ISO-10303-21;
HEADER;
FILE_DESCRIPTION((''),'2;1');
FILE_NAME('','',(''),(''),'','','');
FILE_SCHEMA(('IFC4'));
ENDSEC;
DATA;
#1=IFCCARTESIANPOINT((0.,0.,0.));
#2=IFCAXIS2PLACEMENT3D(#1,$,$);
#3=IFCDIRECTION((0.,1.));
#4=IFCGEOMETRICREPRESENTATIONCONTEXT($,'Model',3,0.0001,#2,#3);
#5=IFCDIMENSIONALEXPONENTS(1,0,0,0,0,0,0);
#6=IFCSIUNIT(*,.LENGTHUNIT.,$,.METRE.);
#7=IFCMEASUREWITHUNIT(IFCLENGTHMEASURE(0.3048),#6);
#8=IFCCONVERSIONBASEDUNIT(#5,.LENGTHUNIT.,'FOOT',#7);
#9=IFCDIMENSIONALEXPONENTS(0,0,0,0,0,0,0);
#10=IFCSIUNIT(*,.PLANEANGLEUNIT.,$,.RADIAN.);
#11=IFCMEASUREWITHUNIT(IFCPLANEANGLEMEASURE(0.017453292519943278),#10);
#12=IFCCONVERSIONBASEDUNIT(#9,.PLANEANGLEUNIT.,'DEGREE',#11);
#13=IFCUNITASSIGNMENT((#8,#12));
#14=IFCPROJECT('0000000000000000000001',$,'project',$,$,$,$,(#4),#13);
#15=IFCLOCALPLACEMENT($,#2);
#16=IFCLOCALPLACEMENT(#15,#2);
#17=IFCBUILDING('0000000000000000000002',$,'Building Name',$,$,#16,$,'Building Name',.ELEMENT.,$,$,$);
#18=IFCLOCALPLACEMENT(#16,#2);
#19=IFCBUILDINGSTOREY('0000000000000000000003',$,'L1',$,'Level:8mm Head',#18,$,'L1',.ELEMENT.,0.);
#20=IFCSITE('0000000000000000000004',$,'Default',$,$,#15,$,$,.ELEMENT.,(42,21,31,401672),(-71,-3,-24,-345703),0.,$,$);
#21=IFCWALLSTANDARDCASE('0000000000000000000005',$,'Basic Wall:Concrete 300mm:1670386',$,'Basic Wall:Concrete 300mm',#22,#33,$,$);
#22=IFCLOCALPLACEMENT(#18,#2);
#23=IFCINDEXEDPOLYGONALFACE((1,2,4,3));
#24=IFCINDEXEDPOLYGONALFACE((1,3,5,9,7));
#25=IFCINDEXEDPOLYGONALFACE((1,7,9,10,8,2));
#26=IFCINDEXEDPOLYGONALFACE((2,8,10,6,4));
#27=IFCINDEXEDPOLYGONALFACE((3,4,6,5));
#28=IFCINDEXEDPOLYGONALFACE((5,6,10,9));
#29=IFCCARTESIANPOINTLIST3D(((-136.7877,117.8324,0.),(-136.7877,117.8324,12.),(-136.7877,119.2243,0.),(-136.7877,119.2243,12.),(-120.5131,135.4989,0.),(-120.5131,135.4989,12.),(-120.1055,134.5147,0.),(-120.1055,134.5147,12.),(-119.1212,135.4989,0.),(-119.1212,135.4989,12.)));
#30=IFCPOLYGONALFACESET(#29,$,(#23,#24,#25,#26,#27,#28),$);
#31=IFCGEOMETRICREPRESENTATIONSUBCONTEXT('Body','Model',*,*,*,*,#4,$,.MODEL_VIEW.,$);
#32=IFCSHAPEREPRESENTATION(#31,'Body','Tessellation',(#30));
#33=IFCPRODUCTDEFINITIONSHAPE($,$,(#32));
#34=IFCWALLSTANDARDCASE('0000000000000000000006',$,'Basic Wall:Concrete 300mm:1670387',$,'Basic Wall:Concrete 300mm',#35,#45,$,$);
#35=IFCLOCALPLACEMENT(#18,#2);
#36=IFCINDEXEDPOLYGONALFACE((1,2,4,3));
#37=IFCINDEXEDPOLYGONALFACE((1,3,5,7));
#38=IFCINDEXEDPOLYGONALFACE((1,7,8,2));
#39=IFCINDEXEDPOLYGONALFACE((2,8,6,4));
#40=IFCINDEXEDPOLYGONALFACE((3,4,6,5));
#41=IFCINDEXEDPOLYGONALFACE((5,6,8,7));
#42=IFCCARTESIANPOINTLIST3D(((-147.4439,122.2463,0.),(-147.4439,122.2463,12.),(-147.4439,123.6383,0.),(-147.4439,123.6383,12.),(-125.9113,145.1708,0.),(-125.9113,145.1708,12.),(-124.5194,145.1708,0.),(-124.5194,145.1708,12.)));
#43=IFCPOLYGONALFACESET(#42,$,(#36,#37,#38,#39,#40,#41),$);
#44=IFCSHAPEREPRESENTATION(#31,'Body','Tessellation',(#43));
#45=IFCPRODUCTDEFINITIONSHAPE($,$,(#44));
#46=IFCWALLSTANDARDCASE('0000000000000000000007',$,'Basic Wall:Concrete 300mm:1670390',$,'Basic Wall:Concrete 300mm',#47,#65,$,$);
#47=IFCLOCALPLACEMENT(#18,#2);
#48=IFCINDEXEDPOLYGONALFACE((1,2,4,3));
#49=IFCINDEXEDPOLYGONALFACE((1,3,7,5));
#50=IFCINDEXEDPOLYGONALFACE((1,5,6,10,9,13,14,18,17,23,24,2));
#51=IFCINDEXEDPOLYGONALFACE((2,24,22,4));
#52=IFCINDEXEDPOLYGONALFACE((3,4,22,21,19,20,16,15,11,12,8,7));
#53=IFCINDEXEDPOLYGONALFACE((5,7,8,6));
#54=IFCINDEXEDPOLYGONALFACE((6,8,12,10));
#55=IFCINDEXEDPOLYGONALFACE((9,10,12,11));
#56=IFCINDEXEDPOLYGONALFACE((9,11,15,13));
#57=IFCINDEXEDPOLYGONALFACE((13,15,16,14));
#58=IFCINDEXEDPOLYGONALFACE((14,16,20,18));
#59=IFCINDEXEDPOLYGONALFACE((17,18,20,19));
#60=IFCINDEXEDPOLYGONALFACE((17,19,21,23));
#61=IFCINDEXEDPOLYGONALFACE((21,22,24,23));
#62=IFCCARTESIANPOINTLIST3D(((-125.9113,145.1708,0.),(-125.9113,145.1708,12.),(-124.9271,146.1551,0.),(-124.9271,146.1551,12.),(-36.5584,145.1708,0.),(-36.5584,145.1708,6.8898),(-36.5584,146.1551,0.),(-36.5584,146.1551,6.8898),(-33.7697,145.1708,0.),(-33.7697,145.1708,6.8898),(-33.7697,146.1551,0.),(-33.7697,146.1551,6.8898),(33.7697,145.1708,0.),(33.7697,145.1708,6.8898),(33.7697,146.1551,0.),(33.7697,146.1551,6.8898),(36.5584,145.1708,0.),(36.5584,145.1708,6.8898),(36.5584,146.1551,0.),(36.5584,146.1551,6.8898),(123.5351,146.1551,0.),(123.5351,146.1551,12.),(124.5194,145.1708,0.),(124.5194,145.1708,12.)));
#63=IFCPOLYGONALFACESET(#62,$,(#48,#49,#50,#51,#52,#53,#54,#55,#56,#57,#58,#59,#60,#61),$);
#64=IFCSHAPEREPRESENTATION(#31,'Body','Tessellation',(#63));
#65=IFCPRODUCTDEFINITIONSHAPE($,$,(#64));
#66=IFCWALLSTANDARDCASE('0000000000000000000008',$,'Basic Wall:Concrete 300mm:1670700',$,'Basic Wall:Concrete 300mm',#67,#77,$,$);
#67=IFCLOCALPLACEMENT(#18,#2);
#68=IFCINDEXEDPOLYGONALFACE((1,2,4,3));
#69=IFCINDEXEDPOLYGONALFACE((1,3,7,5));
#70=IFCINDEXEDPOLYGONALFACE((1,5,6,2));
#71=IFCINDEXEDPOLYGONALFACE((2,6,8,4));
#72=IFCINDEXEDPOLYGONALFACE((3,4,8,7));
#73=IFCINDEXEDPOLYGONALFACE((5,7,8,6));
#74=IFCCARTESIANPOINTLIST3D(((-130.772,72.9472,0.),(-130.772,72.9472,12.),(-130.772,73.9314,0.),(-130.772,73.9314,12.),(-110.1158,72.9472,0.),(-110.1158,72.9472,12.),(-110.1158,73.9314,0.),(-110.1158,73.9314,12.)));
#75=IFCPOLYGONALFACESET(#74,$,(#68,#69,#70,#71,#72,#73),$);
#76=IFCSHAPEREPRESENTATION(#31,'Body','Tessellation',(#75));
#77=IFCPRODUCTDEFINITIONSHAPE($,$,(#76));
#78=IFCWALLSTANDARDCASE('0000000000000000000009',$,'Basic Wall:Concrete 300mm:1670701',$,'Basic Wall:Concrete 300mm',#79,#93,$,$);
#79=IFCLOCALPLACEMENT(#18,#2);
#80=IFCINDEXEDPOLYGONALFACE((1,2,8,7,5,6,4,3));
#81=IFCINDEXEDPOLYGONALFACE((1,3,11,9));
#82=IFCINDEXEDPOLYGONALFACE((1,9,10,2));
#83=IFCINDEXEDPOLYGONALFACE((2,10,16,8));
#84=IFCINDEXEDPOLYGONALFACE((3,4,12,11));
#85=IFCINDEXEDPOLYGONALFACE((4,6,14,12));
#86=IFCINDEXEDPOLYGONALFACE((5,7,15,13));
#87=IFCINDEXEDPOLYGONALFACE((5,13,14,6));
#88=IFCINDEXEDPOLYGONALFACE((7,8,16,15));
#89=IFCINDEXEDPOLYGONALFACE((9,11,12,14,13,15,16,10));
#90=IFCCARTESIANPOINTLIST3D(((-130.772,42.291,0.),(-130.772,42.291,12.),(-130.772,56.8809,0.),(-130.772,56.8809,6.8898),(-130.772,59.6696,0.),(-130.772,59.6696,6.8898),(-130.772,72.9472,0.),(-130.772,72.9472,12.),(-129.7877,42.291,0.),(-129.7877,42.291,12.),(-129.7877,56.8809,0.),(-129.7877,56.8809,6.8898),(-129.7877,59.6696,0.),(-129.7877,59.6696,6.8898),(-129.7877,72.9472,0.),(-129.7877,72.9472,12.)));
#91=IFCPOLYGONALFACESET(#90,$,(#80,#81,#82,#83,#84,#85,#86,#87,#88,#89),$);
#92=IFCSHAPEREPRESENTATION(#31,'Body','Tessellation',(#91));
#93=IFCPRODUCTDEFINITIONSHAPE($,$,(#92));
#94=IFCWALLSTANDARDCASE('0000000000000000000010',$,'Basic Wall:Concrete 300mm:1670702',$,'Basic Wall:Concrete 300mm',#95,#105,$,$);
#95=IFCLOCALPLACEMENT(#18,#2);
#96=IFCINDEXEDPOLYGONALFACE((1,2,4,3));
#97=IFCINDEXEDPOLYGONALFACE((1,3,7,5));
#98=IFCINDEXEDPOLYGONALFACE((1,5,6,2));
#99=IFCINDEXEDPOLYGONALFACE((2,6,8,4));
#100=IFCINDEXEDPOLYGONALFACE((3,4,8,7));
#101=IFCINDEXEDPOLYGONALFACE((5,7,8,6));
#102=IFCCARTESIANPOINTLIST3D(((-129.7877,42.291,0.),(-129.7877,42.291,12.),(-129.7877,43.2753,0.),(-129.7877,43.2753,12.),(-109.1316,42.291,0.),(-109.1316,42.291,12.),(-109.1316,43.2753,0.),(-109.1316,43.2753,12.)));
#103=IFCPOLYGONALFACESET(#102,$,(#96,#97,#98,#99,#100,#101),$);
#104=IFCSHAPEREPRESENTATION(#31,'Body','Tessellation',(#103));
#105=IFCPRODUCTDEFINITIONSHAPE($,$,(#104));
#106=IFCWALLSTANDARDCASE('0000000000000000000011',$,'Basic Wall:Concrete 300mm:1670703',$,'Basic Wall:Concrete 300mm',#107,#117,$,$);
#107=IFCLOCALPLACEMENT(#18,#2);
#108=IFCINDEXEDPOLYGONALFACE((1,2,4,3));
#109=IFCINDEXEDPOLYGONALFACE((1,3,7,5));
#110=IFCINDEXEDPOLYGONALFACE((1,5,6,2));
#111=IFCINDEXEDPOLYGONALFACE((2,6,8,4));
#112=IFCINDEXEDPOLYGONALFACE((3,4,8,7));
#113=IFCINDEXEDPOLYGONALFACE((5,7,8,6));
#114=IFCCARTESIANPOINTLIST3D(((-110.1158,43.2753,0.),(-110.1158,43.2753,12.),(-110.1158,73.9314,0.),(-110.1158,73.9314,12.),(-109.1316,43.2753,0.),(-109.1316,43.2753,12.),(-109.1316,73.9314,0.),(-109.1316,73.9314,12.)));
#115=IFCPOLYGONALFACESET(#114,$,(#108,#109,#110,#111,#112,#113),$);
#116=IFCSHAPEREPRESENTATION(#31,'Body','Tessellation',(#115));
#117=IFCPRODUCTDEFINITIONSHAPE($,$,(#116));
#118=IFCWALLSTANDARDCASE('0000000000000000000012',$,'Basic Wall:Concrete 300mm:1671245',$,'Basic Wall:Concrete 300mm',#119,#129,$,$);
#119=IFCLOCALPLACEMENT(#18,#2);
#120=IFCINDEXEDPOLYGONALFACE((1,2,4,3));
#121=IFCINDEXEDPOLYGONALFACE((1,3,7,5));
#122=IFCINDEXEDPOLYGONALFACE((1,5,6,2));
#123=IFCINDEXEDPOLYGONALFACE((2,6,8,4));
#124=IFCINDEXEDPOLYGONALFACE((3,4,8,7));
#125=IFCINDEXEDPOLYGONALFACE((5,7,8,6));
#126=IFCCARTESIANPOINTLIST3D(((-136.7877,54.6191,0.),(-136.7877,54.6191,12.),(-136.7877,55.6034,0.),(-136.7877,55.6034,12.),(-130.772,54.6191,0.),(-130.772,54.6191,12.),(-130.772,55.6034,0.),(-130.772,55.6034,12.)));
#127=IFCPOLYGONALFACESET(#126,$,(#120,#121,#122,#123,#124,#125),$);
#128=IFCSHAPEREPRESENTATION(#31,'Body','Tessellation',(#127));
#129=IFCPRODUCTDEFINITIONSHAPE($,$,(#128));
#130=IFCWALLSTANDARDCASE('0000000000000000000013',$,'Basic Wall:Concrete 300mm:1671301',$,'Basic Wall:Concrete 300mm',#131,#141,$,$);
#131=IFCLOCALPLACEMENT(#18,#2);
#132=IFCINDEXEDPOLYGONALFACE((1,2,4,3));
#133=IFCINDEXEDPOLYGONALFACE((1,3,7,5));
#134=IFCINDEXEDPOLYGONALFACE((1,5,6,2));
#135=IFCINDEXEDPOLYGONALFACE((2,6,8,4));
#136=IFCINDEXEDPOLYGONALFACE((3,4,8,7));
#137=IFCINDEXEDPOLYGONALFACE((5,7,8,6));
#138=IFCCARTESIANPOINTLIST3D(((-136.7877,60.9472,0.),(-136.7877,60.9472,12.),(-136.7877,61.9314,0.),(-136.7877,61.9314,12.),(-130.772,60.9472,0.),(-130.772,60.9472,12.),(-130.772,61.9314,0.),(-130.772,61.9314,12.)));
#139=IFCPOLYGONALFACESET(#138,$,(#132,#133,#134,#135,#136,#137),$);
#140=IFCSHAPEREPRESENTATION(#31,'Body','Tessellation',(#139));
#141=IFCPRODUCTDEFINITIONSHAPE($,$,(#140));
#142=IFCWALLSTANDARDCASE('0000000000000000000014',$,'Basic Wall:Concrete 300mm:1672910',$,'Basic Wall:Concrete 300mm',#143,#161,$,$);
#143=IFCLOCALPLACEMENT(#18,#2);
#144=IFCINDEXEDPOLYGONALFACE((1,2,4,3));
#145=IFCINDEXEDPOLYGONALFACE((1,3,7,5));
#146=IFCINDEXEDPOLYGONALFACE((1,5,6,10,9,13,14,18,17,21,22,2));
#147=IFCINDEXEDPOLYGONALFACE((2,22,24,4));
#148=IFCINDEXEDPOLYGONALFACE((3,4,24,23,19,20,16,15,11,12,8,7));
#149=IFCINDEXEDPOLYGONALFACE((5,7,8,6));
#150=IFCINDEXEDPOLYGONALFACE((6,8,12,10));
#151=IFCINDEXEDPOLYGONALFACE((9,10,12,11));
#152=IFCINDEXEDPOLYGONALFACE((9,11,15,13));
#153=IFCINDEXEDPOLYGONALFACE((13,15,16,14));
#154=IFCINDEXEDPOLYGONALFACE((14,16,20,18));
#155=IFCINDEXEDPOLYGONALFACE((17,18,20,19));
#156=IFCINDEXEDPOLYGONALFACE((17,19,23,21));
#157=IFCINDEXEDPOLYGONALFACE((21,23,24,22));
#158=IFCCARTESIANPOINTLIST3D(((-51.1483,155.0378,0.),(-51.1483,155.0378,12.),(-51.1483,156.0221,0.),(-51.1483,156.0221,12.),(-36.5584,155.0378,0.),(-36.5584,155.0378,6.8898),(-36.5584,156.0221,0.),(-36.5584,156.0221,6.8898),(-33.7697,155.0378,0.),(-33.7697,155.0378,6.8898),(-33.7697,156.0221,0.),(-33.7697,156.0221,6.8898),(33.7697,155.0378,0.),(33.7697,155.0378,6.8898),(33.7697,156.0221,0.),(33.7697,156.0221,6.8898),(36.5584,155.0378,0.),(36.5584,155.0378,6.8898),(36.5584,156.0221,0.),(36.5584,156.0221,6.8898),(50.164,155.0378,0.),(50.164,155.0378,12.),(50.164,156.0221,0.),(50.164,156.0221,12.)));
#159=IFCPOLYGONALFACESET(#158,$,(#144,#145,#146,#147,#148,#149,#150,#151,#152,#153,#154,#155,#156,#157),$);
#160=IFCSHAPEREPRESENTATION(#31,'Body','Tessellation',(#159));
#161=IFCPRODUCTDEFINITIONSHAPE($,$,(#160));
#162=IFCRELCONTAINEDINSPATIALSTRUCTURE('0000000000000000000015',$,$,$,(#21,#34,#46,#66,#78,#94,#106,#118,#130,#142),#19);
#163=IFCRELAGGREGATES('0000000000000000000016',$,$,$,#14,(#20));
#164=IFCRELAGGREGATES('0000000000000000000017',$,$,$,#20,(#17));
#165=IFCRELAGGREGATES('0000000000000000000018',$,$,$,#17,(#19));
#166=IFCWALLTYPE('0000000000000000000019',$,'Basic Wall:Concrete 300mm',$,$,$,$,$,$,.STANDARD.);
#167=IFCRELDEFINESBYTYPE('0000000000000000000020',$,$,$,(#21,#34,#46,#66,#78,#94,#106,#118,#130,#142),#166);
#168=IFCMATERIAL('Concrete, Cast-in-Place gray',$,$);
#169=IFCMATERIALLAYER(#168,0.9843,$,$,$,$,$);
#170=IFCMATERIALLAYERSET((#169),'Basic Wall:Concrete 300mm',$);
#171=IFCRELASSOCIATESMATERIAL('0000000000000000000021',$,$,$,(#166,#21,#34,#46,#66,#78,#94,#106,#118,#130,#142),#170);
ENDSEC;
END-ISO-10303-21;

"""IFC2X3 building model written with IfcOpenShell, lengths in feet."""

from ifc_helpers import new_model, entity, si_unit, converted_unit, direction, frame, frame_2d, origin, place, context, subcontext, project, spatial, polyline, rectangle, outline, extrude, material, layer, layer_set, layer_usage, type_object, element, save


model = new_model("IFC2X3")

# Units and contexts
model_context = context("Model", 3, precision=0.0001, world=origin(), true_north=direction((0.0, 1.0)))
body_context = subcontext(model_context, "Body", "Model", "MODEL_VIEW")
ifc_project = project(units=[converted_unit("LENGTHUNIT", "FOOT", entity("IfcLengthMeasure", 0.3048), si_unit("LENGTHUNIT", "METRE"), dimensions=[1, 0, 0, 0, 0, 0, 0]), converted_unit("PLANEANGLEUNIT", "DEGREE", entity("IfcPlaneAngleMeasure", 0.017453292519943278), si_unit("PLANEANGLEUNIT", "RADIAN"), dimensions=[0, 0, 0, 0, 0, 0, 0])], contexts=[model_context])

# Site, building, storey
site_placement = place(None, origin())
site = spatial("IfcSite", under=ifc_project, at=site_placement, Name="Default", CompositionType="ELEMENT", RefLatitude=(42, 21, 31, 401672), RefLongitude=(-71, -3, -24, -345703), RefElevation=0.0)
building_placement = place(site_placement, origin())
building = spatial("IfcBuilding", under=site, at=building_placement, Name="Building Name", LongName="Building Name", CompositionType="ELEMENT")
storey_placement = place(building_placement, origin())
storey = spatial("IfcBuildingStorey", under=building, at=storey_placement, Name="L1", ObjectType="Level:8mm Head", LongName="L1", CompositionType="ELEMENT", Elevation=0.0)

# Walls
ifc_material_1 = material(Name="Concrete, Cast-in-Place gray")
ifc_layer = layer(ifc_material_1, 0.9843)
ifc_layer_set = layer_set([ifc_layer], Name="Basic Wall:Concrete 300mm")
ifc_layer_usage_1 = layer_usage(ifc_layer_set, "AXIS2", "POSITIVE", -0.4921)
wall_type = type_object("IfcWallType", Name="Basic Wall:Concrete 300mm", PredefinedType="STANDARD", material=ifc_layer_set)
wall_1_placement = place(storey_placement, frame((-137.1357, 118.1804, 0.0), z_axis=(0.0, 0.0, 1.0), x_axis=(0.707107, 0.707107, 0.0)))
element("IfcWallStandardCase", 1, at=wall_1_placement, inside=storey, type_object=wall_type, material=ifc_layer_usage_1, Name="Basic Wall:Concrete 300mm:1670386", ObjectType="Basic Wall:Concrete 300mm", context=body_context, shape_type="SweptSolid", body=[
    extrude(outline(polyline([(24.9843, -0.4921), (24.0, 0.4921), (0.9843, 0.4921), (0.0, -0.4921), (23.5923, -0.4921), (24.9843, -0.4921)])), origin(), (0.0, 0.0, 1.0), 12.0),
])
ifc_layer_usage_2 = layer_usage(ifc_layer_set, "AXIS2", "POSITIVE", -0.4921)
wall_2_placement = place(storey_placement, frame((-124.8674, 145.5188, 0.0), z_axis=(0.0, 0.0, 1.0), x_axis=(-0.707107, -0.707107, 0.0)))
element("IfcWallStandardCase", 2, at=wall_2_placement, inside=storey, type_object=wall_type, material=ifc_layer_usage_2, Name="Basic Wall:Concrete 300mm:1670387", ObjectType="Basic Wall:Concrete 300mm", context=body_context, shape_type="SweptSolid", body=[
    extrude(outline(polyline([(31.4359, -0.4921), (32.4202, 0.4921), (0.0, 0.4921), (0.9843, -0.4921), (31.4359, -0.4921)])), origin(), (0.0, 0.0, 1.0), 12.0),
])

# Wall, openings
ifc_layer_usage_3 = layer_usage(ifc_layer_set, "AXIS2", "POSITIVE", -0.4921)
wall_3_placement = place(storey_placement, frame((-125.9113, 145.663, 0.0)))
wall_3 = element("IfcWallStandardCase", 3, at=wall_3_placement, inside=storey, type_object=wall_type, material=ifc_layer_usage_3, Name="Basic Wall:Concrete 300mm:1670390", ObjectType="Basic Wall:Concrete 300mm", context=body_context, shape_type="SweptSolid", body=[
    extrude(outline(polyline([(0.0, -0.4921), (1.3919, -0.4921), (250.4307, -0.4921), (249.4465, 0.4921), (164.7315, 0.4921), (163.7473, 0.4921), (158.4035, 0.4921), (157.4192, 0.4921), (94.4035, 0.4921), (93.4192, 0.4921), (88.0754, 0.4921), (87.0911, 0.4921), (0.9843, 0.4921), (0.0, -0.4921)])), origin(), (0.0, 0.0, 1.0), 12.0),
])
opening_1_placement = place(wall_3_placement, frame((162.4697, 0.4921, 0.0)))
element("IfcOpeningElement", 4, at=opening_1_placement, cuts=wall_3, ObjectType="Opening", context=body_context, shape_type="SweptSolid", body=[
    extrude(rectangle(XDim=6.8898, YDim=2.7887, at=frame_2d((3.4449, 1.3944), x_axis=(1.0, 0.0))), frame((0.0, 0.0, 0.0), z_axis=(0.0, -1.0, 0.0), x_axis=(0.0, 0.0, 1.0)), (0.0, 0.0, 1.0), 0.9843),
])
opening_2_placement = place(wall_3_placement, frame((92.1416, 0.4921, 0.0)))
element("IfcOpeningElement", 5, at=opening_2_placement, cuts=wall_3, ObjectType="Opening", context=body_context, shape_type="SweptSolid", body=[
    extrude(rectangle(XDim=6.8898, YDim=2.7887, at=frame_2d((3.4449, 1.3944), x_axis=(1.0, 0.0))), frame((0.0, 0.0, 0.0), z_axis=(0.0, -1.0, 0.0), x_axis=(0.0, 0.0, 1.0)), (0.0, 0.0, 1.0), 0.9843),
])

# Wall
ifc_layer_usage_4 = layer_usage(ifc_layer_set, "AXIS2", "NEGATIVE", 0.4921)
wall_4_placement = place(storey_placement, frame((-130.772, 73.4393, 0.0)))
element("IfcWallStandardCase", 6, at=wall_4_placement, inside=storey, type_object=wall_type, material=ifc_layer_usage_4, Name="Basic Wall:Concrete 300mm:1670700", ObjectType="Basic Wall:Concrete 300mm", context=body_context, shape_type="SweptSolid", body=[
    extrude(rectangle(XDim=20.6562, YDim=0.9843, at=frame_2d((10.3281, 0.0), x_axis=(-1.0, 0.0))), origin(), (0.0, 0.0, 1.0), 12.0),
])

# Wall, opening
ifc_layer_usage_5 = layer_usage(ifc_layer_set, "AXIS2", "NEGATIVE", 0.4921)
wall_5_placement = place(storey_placement, frame((-130.2799, 42.291, 0.0), z_axis=(0.0, 0.0, 1.0), x_axis=(0.0, 1.0, 0.0)))
wall_5 = element("IfcWallStandardCase", 7, at=wall_5_placement, inside=storey, type_object=wall_type, material=ifc_layer_usage_5, Name="Basic Wall:Concrete 300mm:1670701", ObjectType="Basic Wall:Concrete 300mm", context=body_context, shape_type="SweptSolid", body=[
    extrude(rectangle(XDim=30.6562, YDim=0.9843, at=frame_2d((15.3281, 0.0), x_axis=(1.0, 0.0))), origin(), (0.0, 0.0, 1.0), 12.0),
])
opening_3_placement = place(wall_5_placement, frame((14.5899, -0.4921, 0.0)))
element("IfcOpeningElement", 8, at=opening_3_placement, cuts=wall_5, ObjectType="Opening", context=body_context, shape_type="SweptSolid", body=[
    extrude(rectangle(XDim=6.8898, YDim=2.7887, at=frame_2d((3.4449, 1.3944), x_axis=(1.0, 0.0))), frame((0.0, 0.0, 0.0), z_axis=(0.0, 1.0, 0.0), x_axis=(0.0, 0.0, 1.0)), (0.0, 0.0, 1.0), 0.9843),
])

# Walls
ifc_layer_usage_6 = layer_usage(ifc_layer_set, "AXIS2", "NEGATIVE", 0.4921)
wall_6_placement = place(storey_placement, frame((-109.1316, 42.7832, 0.0), z_axis=(0.0, 0.0, 1.0), x_axis=(-1.0, 0.0, 0.0)))
element("IfcWallStandardCase", 9, at=wall_6_placement, inside=storey, type_object=wall_type, material=ifc_layer_usage_6, Name="Basic Wall:Concrete 300mm:1670702", ObjectType="Basic Wall:Concrete 300mm", context=body_context, shape_type="SweptSolid", body=[
    extrude(rectangle(XDim=20.6562, YDim=0.9843, at=frame_2d((10.3281, 0.0), x_axis=(-1.0, 0.0))), origin(), (0.0, 0.0, 1.0), 12.0),
])
ifc_layer_usage_7 = layer_usage(ifc_layer_set, "AXIS2", "NEGATIVE", 0.4921)
wall_7_placement = place(storey_placement, frame((-109.6237, 73.9314, 0.0), z_axis=(0.0, 0.0, 1.0), x_axis=(0.0, -1.0, 0.0)))
element("IfcWallStandardCase", 10, at=wall_7_placement, inside=storey, type_object=wall_type, material=ifc_layer_usage_7, Name="Basic Wall:Concrete 300mm:1670703", ObjectType="Basic Wall:Concrete 300mm", context=body_context, shape_type="SweptSolid", body=[
    extrude(rectangle(XDim=30.6562, YDim=0.9843, at=frame_2d((15.3281, 0.0), x_axis=(-1.0, 0.0))), origin(), (0.0, 0.0, 1.0), 12.0),
])
ifc_layer_usage_8 = layer_usage(ifc_layer_set, "AXIS2", "NEGATIVE", 0.4921)
wall_8_placement = place(storey_placement, frame((-130.772, 55.1112, 0.0), z_axis=(0.0, 0.0, 1.0), x_axis=(-1.0, 0.0, 0.0)))
element("IfcWallStandardCase", 11, at=wall_8_placement, inside=storey, type_object=wall_type, material=ifc_layer_usage_8, Name="Basic Wall:Concrete 300mm:1671245", ObjectType="Basic Wall:Concrete 300mm", context=body_context, shape_type="SweptSolid", body=[
    extrude(rectangle(XDim=6.0157, YDim=0.9843, at=frame_2d((3.0079, 0.0), x_axis=(-1.0, 0.0))), origin(), (0.0, 0.0, 1.0), 12.0),
])
ifc_layer_usage_9 = layer_usage(ifc_layer_set, "AXIS2", "NEGATIVE", 0.4921)
wall_9_placement = place(storey_placement, frame((-130.772, 61.4393, 0.0), z_axis=(0.0, 0.0, 1.0), x_axis=(-1.0, 0.0, 0.0)))
element("IfcWallStandardCase", 12, at=wall_9_placement, inside=storey, type_object=wall_type, material=ifc_layer_usage_9, Name="Basic Wall:Concrete 300mm:1671301", ObjectType="Basic Wall:Concrete 300mm", context=body_context, shape_type="SweptSolid", body=[
    extrude(rectangle(XDim=6.0157, YDim=0.9843, at=frame_2d((3.0079, 0.0), x_axis=(-1.0, 0.0))), origin(), (0.0, 0.0, 1.0), 12.0),
])

# Wall, openings
ifc_layer_usage_10 = layer_usage(ifc_layer_set, "AXIS2", "POSITIVE", -0.4921)
wall_10_placement = place(storey_placement, frame((-51.1483, 155.5299, 0.0)))
wall_10 = element("IfcWallStandardCase", 13, at=wall_10_placement, inside=storey, type_object=wall_type, material=ifc_layer_usage_10, Name="Basic Wall:Concrete 300mm:1672910", ObjectType="Basic Wall:Concrete 300mm", context=body_context, shape_type="SweptSolid", body=[
    extrude(rectangle(XDim=101.3123, YDim=0.9843, at=frame_2d((50.6562, 0.0), x_axis=(1.0, 0.0))), origin(), (0.0, 0.0, 1.0), 12.0),
])
opening_4_placement = place(wall_10_placement, frame((17.3786, 0.4921, 0.0)))
element("IfcOpeningElement", 14, at=opening_4_placement, cuts=wall_10, ObjectType="Opening", context=body_context, shape_type="SweptSolid", body=[
    extrude(rectangle(XDim=6.8898, YDim=2.7887, at=frame_2d((3.4449, 1.3944), x_axis=(1.0, 0.0))), frame((0.0, 0.0, 0.0), z_axis=(0.0, -1.0, 0.0), x_axis=(0.0, 0.0, 1.0)), (0.0, 0.0, 1.0), 0.9843),
])
opening_5_placement = place(wall_10_placement, frame((87.7067, 0.4921, 0.0)))
element("IfcOpeningElement", 15, at=opening_5_placement, cuts=wall_10, ObjectType="Opening", context=body_context, shape_type="SweptSolid", body=[
    extrude(rectangle(XDim=6.8898, YDim=2.7887, at=frame_2d((3.4449, 1.3944), x_axis=(1.0, 0.0))), frame((0.0, 0.0, 0.0), z_axis=(0.0, -1.0, 0.0), x_axis=(0.0, 0.0, 1.0)), (0.0, 0.0, 1.0), 0.9843),
])

save(model, "model.ifc")
